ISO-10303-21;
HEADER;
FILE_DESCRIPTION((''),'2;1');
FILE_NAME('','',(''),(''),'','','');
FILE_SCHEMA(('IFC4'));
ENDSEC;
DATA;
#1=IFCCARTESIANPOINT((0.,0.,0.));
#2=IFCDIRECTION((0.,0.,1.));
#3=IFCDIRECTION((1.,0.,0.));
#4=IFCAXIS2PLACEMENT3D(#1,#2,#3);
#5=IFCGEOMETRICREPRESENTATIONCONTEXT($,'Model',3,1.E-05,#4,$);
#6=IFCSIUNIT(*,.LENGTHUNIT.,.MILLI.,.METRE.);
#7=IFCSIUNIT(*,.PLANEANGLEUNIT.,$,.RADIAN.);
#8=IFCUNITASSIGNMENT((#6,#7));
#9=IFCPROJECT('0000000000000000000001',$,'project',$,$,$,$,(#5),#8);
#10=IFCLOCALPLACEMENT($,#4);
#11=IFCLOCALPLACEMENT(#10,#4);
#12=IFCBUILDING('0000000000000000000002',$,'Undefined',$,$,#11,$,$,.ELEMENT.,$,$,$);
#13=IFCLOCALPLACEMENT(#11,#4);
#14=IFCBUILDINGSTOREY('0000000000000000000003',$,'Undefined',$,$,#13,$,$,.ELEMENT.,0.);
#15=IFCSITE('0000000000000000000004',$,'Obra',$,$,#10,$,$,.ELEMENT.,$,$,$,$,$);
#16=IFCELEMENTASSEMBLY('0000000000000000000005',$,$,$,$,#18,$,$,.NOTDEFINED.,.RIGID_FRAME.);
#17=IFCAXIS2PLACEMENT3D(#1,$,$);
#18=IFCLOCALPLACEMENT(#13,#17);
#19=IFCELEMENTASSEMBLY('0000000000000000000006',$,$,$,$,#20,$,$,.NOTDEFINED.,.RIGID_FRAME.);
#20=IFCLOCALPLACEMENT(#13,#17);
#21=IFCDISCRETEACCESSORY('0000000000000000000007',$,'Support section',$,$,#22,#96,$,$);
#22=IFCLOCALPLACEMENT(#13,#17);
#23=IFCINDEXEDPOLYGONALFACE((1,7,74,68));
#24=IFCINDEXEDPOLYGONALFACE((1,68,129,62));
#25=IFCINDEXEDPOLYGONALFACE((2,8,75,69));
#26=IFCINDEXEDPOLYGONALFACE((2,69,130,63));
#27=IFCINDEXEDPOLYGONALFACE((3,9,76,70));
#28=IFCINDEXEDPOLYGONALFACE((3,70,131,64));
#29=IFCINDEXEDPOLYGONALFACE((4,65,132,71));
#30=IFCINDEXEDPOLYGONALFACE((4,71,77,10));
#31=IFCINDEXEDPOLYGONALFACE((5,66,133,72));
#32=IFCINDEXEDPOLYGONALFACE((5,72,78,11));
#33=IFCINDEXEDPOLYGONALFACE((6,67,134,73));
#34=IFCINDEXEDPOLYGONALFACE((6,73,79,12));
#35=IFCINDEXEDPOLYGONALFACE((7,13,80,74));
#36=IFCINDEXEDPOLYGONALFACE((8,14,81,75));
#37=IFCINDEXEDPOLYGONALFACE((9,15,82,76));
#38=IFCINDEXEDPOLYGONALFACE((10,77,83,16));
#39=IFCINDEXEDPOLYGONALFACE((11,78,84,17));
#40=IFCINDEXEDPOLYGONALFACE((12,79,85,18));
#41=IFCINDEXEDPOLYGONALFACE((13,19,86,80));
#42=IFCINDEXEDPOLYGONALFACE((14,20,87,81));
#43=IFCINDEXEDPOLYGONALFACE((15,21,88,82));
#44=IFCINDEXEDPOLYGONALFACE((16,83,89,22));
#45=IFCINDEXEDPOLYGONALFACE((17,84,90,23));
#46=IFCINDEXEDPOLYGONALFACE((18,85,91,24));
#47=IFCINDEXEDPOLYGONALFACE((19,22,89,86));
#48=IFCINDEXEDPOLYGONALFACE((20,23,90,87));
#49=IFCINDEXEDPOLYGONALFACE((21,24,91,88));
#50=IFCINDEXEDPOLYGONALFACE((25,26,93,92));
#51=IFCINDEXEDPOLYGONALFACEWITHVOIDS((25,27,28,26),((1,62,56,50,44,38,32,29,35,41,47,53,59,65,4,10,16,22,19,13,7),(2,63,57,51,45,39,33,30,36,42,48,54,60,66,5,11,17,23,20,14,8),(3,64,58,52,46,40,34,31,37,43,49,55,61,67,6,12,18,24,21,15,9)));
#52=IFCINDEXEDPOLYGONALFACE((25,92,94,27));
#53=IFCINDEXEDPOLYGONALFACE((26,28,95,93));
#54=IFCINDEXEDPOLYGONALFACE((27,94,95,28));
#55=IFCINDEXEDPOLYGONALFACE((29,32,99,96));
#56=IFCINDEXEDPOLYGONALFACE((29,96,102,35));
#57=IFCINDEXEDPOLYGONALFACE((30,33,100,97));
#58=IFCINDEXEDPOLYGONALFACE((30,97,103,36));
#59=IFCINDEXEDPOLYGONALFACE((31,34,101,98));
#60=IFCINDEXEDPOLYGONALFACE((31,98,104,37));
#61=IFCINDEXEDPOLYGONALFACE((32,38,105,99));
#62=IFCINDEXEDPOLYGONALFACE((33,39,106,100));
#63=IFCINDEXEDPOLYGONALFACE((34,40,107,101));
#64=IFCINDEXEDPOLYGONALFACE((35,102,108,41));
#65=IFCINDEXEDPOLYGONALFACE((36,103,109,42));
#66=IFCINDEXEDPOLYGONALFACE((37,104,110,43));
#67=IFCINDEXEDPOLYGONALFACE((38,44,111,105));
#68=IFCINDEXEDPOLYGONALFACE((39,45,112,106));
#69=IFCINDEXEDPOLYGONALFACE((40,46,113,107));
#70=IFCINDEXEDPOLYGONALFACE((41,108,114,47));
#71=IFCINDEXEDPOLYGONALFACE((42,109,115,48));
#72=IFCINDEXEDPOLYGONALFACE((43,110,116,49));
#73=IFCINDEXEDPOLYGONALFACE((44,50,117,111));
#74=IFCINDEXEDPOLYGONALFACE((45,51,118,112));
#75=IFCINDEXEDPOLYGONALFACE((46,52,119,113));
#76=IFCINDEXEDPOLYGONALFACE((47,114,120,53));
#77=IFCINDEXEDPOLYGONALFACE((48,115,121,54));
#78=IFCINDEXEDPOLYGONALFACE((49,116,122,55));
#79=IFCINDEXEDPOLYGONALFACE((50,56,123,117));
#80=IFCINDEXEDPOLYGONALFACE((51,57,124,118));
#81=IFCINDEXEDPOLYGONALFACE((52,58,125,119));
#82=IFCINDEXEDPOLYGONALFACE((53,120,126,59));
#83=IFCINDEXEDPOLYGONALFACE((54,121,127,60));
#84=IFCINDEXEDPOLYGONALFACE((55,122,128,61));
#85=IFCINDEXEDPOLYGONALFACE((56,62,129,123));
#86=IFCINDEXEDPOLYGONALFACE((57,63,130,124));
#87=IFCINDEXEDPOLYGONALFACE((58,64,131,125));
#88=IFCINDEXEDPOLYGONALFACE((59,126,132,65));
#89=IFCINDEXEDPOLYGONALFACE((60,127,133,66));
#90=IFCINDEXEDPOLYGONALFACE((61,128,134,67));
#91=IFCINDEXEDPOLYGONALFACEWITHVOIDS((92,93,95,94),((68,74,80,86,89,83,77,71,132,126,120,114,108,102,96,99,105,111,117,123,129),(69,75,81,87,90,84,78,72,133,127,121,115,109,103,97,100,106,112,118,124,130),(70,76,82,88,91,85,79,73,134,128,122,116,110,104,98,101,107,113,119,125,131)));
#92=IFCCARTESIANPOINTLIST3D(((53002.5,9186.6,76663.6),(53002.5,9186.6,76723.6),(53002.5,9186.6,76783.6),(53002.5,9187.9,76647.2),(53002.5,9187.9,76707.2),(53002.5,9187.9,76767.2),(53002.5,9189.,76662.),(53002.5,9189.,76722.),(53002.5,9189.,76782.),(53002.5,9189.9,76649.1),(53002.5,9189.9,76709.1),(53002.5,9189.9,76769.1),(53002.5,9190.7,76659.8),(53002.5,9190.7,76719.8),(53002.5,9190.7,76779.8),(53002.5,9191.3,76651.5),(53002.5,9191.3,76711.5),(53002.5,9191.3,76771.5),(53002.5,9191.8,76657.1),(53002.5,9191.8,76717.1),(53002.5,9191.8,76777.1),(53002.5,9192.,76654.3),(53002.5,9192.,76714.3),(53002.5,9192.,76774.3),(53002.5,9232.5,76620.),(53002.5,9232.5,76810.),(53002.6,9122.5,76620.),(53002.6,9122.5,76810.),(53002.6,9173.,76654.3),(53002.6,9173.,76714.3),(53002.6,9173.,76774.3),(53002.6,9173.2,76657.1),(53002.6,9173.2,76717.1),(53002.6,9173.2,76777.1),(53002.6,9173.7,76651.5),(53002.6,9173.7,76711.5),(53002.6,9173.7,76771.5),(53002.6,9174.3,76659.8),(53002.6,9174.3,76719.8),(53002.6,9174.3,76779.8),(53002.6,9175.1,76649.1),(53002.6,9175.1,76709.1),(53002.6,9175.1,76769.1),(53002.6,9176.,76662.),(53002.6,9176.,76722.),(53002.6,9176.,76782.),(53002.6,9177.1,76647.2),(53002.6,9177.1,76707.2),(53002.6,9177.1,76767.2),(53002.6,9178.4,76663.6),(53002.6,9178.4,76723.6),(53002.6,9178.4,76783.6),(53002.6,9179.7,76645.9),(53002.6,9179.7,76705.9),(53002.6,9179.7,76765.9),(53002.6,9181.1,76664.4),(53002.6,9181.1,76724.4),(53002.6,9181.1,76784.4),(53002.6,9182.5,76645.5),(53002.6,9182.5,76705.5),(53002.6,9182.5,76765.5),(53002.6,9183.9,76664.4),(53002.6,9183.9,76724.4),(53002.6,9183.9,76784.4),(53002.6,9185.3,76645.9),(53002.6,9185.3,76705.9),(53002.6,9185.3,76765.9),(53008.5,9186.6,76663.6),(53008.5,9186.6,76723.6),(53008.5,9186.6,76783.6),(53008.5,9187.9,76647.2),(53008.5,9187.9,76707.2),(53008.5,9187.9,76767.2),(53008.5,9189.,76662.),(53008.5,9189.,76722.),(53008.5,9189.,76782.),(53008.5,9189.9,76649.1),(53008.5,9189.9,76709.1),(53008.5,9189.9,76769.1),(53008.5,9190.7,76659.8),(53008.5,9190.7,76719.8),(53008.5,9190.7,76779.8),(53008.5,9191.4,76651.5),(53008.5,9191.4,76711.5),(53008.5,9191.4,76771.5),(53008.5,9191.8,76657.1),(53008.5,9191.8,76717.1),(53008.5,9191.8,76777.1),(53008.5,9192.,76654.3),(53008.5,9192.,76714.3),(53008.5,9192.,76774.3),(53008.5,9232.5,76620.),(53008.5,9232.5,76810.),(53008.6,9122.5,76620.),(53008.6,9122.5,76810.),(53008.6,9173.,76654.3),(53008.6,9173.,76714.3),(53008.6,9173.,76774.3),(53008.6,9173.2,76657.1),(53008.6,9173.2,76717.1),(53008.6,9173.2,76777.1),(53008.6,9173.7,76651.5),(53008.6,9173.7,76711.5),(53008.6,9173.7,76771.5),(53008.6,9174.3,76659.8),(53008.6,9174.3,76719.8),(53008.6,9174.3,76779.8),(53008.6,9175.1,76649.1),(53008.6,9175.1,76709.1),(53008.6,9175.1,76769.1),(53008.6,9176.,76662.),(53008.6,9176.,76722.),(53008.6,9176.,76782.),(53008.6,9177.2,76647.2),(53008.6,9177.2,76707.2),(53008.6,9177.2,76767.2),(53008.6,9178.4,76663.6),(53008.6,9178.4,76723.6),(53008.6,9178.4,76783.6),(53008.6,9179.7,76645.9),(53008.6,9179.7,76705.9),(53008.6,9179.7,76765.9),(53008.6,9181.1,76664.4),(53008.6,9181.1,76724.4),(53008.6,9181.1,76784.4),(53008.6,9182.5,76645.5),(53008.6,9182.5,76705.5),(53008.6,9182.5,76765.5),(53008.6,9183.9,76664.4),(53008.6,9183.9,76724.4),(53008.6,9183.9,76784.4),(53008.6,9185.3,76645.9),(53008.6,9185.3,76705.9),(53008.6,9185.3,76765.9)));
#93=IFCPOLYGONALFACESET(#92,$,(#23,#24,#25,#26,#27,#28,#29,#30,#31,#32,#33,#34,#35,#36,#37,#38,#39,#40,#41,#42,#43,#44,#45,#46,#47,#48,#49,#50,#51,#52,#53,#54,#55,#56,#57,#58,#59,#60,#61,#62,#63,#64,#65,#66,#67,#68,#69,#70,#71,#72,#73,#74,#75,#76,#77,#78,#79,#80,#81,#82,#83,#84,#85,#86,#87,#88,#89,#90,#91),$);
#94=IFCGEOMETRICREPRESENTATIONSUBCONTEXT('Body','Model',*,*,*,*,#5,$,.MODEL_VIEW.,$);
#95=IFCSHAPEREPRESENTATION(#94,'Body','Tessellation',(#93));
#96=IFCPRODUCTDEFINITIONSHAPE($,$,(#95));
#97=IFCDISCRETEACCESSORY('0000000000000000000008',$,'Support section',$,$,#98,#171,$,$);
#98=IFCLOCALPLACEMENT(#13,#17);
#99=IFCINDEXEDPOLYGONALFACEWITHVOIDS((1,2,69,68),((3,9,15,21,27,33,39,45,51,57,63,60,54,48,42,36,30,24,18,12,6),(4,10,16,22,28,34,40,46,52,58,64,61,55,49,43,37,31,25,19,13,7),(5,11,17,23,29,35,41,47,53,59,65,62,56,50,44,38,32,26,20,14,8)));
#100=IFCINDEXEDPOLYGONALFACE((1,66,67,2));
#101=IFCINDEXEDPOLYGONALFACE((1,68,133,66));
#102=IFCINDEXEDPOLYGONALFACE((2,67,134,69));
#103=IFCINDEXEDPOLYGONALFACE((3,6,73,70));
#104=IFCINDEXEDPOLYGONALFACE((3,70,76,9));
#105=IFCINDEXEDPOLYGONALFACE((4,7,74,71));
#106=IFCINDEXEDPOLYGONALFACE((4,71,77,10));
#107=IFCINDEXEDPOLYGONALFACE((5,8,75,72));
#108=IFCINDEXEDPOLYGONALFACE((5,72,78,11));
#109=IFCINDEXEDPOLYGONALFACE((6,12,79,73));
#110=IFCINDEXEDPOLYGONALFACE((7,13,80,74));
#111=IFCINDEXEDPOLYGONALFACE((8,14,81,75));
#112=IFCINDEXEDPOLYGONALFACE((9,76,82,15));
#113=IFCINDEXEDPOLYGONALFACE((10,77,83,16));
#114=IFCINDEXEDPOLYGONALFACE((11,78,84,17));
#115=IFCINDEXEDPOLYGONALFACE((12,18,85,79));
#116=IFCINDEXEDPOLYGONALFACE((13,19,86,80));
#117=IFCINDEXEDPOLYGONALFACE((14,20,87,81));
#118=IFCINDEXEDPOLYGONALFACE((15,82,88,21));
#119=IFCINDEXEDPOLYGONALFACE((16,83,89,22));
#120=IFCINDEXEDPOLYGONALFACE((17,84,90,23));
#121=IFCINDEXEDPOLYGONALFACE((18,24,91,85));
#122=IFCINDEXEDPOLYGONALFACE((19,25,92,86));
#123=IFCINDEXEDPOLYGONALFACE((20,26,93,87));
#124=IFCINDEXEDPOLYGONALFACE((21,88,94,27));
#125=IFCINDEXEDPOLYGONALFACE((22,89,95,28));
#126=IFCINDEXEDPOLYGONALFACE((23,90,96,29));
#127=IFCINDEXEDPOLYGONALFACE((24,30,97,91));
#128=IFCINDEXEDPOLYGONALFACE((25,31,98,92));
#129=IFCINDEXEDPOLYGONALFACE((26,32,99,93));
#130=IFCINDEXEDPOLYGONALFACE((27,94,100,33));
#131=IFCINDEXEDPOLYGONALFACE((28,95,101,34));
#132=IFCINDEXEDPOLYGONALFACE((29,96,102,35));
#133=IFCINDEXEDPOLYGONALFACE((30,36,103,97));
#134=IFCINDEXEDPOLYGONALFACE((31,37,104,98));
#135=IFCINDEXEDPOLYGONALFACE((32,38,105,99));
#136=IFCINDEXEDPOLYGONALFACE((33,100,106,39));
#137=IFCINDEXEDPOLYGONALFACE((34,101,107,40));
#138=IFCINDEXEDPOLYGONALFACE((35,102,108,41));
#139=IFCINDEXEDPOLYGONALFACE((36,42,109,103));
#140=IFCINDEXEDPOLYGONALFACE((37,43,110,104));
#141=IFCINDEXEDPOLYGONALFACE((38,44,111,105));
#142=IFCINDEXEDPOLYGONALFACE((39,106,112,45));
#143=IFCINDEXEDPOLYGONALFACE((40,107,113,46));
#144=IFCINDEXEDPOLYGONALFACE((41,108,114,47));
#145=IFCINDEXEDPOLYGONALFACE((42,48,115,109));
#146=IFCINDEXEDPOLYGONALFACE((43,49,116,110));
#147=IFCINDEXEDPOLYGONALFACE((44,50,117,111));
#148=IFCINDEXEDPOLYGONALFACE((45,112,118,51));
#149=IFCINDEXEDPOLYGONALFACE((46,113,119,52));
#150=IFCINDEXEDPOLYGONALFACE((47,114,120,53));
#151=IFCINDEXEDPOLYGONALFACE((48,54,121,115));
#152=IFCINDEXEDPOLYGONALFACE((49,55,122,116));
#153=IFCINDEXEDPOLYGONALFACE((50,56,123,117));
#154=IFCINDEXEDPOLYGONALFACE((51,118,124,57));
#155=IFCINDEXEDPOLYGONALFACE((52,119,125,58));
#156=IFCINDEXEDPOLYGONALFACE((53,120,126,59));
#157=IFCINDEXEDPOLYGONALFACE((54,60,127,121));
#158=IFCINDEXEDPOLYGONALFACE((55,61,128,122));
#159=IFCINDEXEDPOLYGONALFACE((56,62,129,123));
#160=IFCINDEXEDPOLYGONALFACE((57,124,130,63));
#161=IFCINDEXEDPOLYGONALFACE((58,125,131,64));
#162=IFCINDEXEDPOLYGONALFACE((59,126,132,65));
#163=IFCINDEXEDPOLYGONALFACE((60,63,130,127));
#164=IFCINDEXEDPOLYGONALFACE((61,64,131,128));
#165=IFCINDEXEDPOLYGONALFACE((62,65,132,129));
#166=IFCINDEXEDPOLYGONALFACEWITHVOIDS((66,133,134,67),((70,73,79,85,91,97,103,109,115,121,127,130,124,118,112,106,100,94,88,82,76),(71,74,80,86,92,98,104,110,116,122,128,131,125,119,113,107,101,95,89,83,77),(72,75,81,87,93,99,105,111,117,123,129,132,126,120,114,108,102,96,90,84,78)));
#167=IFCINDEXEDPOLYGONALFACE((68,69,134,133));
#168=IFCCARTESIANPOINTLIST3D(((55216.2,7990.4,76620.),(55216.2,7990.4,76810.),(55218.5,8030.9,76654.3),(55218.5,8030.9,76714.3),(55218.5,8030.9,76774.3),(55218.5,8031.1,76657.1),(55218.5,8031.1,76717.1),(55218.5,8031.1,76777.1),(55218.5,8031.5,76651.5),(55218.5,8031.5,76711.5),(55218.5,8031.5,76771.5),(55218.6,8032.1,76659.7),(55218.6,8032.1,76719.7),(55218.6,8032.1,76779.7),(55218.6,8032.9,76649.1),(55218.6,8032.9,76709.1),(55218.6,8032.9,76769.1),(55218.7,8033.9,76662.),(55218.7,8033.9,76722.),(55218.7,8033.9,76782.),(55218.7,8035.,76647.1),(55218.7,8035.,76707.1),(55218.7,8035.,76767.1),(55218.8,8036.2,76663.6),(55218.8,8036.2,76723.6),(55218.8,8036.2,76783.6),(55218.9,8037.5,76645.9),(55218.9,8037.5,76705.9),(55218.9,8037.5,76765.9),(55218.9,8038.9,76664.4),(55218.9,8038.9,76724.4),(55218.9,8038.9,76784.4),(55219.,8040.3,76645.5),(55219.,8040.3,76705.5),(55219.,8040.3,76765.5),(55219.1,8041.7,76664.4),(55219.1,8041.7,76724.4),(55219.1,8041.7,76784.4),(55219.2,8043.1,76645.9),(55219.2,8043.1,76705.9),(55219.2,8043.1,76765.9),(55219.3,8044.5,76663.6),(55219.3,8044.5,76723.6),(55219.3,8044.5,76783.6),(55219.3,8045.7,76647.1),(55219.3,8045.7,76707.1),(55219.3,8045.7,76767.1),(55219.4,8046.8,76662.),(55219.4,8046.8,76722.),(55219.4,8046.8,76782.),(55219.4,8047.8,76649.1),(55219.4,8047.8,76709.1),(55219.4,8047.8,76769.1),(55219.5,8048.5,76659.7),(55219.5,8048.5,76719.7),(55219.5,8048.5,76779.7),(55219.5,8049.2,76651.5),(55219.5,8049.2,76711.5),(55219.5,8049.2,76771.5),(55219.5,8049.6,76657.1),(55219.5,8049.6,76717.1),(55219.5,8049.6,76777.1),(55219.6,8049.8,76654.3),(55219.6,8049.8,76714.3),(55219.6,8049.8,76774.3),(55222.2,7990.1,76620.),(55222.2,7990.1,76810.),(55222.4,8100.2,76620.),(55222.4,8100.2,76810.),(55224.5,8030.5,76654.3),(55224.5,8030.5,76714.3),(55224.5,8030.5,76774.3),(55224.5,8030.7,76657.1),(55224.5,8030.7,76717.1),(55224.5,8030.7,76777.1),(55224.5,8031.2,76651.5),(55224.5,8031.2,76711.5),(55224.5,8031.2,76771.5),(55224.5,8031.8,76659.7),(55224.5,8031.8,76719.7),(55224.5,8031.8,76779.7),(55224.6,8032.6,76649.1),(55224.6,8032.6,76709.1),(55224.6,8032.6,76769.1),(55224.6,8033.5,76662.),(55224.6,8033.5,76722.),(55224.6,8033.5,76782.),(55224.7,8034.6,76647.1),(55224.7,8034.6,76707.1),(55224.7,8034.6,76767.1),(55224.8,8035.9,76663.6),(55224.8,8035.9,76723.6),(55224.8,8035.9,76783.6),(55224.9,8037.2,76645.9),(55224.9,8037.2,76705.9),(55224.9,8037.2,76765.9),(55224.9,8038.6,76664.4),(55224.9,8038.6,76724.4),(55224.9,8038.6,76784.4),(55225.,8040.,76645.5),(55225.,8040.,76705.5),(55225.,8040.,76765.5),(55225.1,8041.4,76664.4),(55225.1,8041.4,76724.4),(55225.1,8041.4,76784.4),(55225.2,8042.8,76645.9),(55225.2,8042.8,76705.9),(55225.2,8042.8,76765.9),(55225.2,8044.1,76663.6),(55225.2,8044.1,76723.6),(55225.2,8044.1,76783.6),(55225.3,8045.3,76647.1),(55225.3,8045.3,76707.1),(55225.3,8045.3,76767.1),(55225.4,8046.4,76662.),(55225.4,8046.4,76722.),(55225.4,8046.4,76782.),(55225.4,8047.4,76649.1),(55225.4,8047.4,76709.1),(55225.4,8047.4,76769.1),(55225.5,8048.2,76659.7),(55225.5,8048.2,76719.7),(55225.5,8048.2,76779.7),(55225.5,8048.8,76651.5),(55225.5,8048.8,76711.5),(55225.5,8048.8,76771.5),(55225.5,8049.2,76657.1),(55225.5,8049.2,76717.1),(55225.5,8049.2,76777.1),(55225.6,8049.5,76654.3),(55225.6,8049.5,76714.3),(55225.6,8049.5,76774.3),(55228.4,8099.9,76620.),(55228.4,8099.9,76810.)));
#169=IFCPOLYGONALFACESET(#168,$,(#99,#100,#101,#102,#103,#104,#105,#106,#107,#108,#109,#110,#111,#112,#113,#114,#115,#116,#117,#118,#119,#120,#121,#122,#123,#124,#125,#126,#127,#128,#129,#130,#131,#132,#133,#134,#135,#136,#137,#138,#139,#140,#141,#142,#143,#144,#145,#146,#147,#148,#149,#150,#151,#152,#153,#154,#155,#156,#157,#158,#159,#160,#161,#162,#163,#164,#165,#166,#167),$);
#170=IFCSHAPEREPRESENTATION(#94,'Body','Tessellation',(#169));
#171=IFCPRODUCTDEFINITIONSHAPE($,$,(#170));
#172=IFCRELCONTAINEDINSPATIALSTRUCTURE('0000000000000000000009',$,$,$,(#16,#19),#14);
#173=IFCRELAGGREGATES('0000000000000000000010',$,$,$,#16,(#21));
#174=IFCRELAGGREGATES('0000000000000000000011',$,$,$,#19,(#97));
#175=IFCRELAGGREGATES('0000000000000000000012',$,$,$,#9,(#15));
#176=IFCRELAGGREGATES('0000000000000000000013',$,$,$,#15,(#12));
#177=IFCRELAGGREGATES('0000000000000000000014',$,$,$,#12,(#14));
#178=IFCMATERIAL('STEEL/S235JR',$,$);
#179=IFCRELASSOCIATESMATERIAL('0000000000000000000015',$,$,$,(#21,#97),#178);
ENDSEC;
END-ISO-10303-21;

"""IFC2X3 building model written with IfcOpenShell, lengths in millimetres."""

from ifc_helpers import new_model, si_unit, frame, origin_with_axes, origin_2d_with_axis, place, context, subcontext, project, spatial, rectangle, circle, extrude, source, transform, mapped, material, element, aggregate, save


model = new_model("IFC2X3")

# Units and contexts
model_context = context("Model", 3, precision=1e-05, world=origin_with_axes())
body_context = subcontext(model_context, "Body", "Model", "MODEL_VIEW")
ifc_project = project(units=[si_unit("LENGTHUNIT", "METRE", prefix="MILLI"), si_unit("PLANEANGLEUNIT", "RADIAN")], contexts=[model_context])

# Site, building, storey
site_placement = place(None, origin_with_axes())
site = spatial("IfcSite", under=ifc_project, at=site_placement, Name="Obra", CompositionType="ELEMENT")
building_placement = place(site_placement, origin_with_axes())
building = spatial("IfcBuilding", under=site, at=building_placement, Name="Undefined", CompositionType="ELEMENT")
storey_placement = place(building_placement, origin_with_axes())
storey = spatial("IfcBuildingStorey", under=building, at=storey_placement, Name="Undefined", CompositionType="ELEMENT", Elevation=0.0)

# Element assemblies
assembly_1_placement = place(storey_placement, origin_with_axes())
assembly_1 = element("IfcElementAssembly", 1, at=assembly_1_placement, inside=storey, AssemblyPlace="NOTDEFINED", PredefinedType="RIGID_FRAME")
ifc_material_1 = material(Name="STEEL/S235JR")
assembly_2_placement = place(storey_placement, origin_with_axes())
assembly_2 = element("IfcElementAssembly", 2, at=assembly_2_placement, inside=storey, AssemblyPlace="NOTDEFINED", PredefinedType="RIGID_FRAME")

# Discrete accessories, openings
discrete_accessory_1_placement = place(assembly_1_placement, frame((53005.6, 9177.5, 76620.0), z_axis=(0.0, 0.0, 1.0), x_axis=(0.001508, -0.999999, 0.0)))
discrete_accessory_1 = element("IfcDiscreteAccessory", 3, at=discrete_accessory_1_placement, material=ifc_material_1, Name="Support section", context=body_context, shape_type="SweptSolid", body=[
    extrude(rectangle(XDim=6.0, YDim=110.0, at=origin_2d_with_axis()), frame((0.0, 0.0, 190.0), z_axis=(0.0, 0.0, -1.0), x_axis=(0.0, 1.0, 0.0)), (0.0, 0.0, 1.0), 190.0),
])
shared_shape_1 = source(origin_with_axes(), body_context, "Body", "SweptSolid", [
    extrude(circle(Radius=9.5, at=origin_2d_with_axis()), frame((0.0, -9.2, 0.0), z_axis=(0.0, 1.0, 0.0), x_axis=(1.0, 0.0, 0.0)), (0.0, 0.0, 1.0), 6.2),
])
opening_1_placement = place(assembly_1_placement, frame((52999.5, 9132.5, 76835.0), z_axis=(-0.001508, 0.999999, 0.0), x_axis=(0.0, 0.0, -1.0)))
element("IfcOpeningElement", 4, at=opening_1_placement, cuts=discrete_accessory_1, ObjectType="Opening", context=body_context, shape_type="MappedRepresentation", body=[
    mapped(shared_shape_1, transform((60.0, 0.0, 50.0))),
    mapped(shared_shape_1, transform((120.0, 0.0, 50.0))),
    mapped(shared_shape_1, transform((180.0, 0.0, 50.0))),
])
aggregate(assembly_1, [discrete_accessory_1])
discrete_accessory_2_placement = place(assembly_2_placement, frame((55222.3, 8045.2, 76620.0), z_axis=(0.0, 0.0, 1.0), x_axis=(0.05711, 0.998368, 0.0)))
discrete_accessory_2 = element("IfcDiscreteAccessory", 5, at=discrete_accessory_2_placement, material=ifc_material_1, Name="Support section", context=body_context, shape_type="SweptSolid", body=[
    extrude(rectangle(XDim=6.0, YDim=110.0, at=origin_2d_with_axis()), frame((0.0, 0.0, 190.0), z_axis=(0.0, 0.0, -1.0), x_axis=(0.0, 1.0, 0.0)), (0.0, 0.0, 1.0), 190.0),
])
opening_2_placement = place(assembly_2_placement, frame((55231.0, 8089.7, 76835.0), z_axis=(-0.05711, -0.998368, 0.0), x_axis=(0.0, 0.0, -1.0)))
element("IfcOpeningElement", 6, at=opening_2_placement, cuts=discrete_accessory_2, ObjectType="Opening", context=body_context, shape_type="MappedRepresentation", body=[
    mapped(shared_shape_1, transform((60.0, 0.0, 50.0))),
    mapped(shared_shape_1, transform((120.0, 0.0, 50.0))),
    mapped(shared_shape_1, transform((180.0, 0.0, 50.0))),
])
aggregate(assembly_2, [discrete_accessory_2])

save(model, "model.ifc")
